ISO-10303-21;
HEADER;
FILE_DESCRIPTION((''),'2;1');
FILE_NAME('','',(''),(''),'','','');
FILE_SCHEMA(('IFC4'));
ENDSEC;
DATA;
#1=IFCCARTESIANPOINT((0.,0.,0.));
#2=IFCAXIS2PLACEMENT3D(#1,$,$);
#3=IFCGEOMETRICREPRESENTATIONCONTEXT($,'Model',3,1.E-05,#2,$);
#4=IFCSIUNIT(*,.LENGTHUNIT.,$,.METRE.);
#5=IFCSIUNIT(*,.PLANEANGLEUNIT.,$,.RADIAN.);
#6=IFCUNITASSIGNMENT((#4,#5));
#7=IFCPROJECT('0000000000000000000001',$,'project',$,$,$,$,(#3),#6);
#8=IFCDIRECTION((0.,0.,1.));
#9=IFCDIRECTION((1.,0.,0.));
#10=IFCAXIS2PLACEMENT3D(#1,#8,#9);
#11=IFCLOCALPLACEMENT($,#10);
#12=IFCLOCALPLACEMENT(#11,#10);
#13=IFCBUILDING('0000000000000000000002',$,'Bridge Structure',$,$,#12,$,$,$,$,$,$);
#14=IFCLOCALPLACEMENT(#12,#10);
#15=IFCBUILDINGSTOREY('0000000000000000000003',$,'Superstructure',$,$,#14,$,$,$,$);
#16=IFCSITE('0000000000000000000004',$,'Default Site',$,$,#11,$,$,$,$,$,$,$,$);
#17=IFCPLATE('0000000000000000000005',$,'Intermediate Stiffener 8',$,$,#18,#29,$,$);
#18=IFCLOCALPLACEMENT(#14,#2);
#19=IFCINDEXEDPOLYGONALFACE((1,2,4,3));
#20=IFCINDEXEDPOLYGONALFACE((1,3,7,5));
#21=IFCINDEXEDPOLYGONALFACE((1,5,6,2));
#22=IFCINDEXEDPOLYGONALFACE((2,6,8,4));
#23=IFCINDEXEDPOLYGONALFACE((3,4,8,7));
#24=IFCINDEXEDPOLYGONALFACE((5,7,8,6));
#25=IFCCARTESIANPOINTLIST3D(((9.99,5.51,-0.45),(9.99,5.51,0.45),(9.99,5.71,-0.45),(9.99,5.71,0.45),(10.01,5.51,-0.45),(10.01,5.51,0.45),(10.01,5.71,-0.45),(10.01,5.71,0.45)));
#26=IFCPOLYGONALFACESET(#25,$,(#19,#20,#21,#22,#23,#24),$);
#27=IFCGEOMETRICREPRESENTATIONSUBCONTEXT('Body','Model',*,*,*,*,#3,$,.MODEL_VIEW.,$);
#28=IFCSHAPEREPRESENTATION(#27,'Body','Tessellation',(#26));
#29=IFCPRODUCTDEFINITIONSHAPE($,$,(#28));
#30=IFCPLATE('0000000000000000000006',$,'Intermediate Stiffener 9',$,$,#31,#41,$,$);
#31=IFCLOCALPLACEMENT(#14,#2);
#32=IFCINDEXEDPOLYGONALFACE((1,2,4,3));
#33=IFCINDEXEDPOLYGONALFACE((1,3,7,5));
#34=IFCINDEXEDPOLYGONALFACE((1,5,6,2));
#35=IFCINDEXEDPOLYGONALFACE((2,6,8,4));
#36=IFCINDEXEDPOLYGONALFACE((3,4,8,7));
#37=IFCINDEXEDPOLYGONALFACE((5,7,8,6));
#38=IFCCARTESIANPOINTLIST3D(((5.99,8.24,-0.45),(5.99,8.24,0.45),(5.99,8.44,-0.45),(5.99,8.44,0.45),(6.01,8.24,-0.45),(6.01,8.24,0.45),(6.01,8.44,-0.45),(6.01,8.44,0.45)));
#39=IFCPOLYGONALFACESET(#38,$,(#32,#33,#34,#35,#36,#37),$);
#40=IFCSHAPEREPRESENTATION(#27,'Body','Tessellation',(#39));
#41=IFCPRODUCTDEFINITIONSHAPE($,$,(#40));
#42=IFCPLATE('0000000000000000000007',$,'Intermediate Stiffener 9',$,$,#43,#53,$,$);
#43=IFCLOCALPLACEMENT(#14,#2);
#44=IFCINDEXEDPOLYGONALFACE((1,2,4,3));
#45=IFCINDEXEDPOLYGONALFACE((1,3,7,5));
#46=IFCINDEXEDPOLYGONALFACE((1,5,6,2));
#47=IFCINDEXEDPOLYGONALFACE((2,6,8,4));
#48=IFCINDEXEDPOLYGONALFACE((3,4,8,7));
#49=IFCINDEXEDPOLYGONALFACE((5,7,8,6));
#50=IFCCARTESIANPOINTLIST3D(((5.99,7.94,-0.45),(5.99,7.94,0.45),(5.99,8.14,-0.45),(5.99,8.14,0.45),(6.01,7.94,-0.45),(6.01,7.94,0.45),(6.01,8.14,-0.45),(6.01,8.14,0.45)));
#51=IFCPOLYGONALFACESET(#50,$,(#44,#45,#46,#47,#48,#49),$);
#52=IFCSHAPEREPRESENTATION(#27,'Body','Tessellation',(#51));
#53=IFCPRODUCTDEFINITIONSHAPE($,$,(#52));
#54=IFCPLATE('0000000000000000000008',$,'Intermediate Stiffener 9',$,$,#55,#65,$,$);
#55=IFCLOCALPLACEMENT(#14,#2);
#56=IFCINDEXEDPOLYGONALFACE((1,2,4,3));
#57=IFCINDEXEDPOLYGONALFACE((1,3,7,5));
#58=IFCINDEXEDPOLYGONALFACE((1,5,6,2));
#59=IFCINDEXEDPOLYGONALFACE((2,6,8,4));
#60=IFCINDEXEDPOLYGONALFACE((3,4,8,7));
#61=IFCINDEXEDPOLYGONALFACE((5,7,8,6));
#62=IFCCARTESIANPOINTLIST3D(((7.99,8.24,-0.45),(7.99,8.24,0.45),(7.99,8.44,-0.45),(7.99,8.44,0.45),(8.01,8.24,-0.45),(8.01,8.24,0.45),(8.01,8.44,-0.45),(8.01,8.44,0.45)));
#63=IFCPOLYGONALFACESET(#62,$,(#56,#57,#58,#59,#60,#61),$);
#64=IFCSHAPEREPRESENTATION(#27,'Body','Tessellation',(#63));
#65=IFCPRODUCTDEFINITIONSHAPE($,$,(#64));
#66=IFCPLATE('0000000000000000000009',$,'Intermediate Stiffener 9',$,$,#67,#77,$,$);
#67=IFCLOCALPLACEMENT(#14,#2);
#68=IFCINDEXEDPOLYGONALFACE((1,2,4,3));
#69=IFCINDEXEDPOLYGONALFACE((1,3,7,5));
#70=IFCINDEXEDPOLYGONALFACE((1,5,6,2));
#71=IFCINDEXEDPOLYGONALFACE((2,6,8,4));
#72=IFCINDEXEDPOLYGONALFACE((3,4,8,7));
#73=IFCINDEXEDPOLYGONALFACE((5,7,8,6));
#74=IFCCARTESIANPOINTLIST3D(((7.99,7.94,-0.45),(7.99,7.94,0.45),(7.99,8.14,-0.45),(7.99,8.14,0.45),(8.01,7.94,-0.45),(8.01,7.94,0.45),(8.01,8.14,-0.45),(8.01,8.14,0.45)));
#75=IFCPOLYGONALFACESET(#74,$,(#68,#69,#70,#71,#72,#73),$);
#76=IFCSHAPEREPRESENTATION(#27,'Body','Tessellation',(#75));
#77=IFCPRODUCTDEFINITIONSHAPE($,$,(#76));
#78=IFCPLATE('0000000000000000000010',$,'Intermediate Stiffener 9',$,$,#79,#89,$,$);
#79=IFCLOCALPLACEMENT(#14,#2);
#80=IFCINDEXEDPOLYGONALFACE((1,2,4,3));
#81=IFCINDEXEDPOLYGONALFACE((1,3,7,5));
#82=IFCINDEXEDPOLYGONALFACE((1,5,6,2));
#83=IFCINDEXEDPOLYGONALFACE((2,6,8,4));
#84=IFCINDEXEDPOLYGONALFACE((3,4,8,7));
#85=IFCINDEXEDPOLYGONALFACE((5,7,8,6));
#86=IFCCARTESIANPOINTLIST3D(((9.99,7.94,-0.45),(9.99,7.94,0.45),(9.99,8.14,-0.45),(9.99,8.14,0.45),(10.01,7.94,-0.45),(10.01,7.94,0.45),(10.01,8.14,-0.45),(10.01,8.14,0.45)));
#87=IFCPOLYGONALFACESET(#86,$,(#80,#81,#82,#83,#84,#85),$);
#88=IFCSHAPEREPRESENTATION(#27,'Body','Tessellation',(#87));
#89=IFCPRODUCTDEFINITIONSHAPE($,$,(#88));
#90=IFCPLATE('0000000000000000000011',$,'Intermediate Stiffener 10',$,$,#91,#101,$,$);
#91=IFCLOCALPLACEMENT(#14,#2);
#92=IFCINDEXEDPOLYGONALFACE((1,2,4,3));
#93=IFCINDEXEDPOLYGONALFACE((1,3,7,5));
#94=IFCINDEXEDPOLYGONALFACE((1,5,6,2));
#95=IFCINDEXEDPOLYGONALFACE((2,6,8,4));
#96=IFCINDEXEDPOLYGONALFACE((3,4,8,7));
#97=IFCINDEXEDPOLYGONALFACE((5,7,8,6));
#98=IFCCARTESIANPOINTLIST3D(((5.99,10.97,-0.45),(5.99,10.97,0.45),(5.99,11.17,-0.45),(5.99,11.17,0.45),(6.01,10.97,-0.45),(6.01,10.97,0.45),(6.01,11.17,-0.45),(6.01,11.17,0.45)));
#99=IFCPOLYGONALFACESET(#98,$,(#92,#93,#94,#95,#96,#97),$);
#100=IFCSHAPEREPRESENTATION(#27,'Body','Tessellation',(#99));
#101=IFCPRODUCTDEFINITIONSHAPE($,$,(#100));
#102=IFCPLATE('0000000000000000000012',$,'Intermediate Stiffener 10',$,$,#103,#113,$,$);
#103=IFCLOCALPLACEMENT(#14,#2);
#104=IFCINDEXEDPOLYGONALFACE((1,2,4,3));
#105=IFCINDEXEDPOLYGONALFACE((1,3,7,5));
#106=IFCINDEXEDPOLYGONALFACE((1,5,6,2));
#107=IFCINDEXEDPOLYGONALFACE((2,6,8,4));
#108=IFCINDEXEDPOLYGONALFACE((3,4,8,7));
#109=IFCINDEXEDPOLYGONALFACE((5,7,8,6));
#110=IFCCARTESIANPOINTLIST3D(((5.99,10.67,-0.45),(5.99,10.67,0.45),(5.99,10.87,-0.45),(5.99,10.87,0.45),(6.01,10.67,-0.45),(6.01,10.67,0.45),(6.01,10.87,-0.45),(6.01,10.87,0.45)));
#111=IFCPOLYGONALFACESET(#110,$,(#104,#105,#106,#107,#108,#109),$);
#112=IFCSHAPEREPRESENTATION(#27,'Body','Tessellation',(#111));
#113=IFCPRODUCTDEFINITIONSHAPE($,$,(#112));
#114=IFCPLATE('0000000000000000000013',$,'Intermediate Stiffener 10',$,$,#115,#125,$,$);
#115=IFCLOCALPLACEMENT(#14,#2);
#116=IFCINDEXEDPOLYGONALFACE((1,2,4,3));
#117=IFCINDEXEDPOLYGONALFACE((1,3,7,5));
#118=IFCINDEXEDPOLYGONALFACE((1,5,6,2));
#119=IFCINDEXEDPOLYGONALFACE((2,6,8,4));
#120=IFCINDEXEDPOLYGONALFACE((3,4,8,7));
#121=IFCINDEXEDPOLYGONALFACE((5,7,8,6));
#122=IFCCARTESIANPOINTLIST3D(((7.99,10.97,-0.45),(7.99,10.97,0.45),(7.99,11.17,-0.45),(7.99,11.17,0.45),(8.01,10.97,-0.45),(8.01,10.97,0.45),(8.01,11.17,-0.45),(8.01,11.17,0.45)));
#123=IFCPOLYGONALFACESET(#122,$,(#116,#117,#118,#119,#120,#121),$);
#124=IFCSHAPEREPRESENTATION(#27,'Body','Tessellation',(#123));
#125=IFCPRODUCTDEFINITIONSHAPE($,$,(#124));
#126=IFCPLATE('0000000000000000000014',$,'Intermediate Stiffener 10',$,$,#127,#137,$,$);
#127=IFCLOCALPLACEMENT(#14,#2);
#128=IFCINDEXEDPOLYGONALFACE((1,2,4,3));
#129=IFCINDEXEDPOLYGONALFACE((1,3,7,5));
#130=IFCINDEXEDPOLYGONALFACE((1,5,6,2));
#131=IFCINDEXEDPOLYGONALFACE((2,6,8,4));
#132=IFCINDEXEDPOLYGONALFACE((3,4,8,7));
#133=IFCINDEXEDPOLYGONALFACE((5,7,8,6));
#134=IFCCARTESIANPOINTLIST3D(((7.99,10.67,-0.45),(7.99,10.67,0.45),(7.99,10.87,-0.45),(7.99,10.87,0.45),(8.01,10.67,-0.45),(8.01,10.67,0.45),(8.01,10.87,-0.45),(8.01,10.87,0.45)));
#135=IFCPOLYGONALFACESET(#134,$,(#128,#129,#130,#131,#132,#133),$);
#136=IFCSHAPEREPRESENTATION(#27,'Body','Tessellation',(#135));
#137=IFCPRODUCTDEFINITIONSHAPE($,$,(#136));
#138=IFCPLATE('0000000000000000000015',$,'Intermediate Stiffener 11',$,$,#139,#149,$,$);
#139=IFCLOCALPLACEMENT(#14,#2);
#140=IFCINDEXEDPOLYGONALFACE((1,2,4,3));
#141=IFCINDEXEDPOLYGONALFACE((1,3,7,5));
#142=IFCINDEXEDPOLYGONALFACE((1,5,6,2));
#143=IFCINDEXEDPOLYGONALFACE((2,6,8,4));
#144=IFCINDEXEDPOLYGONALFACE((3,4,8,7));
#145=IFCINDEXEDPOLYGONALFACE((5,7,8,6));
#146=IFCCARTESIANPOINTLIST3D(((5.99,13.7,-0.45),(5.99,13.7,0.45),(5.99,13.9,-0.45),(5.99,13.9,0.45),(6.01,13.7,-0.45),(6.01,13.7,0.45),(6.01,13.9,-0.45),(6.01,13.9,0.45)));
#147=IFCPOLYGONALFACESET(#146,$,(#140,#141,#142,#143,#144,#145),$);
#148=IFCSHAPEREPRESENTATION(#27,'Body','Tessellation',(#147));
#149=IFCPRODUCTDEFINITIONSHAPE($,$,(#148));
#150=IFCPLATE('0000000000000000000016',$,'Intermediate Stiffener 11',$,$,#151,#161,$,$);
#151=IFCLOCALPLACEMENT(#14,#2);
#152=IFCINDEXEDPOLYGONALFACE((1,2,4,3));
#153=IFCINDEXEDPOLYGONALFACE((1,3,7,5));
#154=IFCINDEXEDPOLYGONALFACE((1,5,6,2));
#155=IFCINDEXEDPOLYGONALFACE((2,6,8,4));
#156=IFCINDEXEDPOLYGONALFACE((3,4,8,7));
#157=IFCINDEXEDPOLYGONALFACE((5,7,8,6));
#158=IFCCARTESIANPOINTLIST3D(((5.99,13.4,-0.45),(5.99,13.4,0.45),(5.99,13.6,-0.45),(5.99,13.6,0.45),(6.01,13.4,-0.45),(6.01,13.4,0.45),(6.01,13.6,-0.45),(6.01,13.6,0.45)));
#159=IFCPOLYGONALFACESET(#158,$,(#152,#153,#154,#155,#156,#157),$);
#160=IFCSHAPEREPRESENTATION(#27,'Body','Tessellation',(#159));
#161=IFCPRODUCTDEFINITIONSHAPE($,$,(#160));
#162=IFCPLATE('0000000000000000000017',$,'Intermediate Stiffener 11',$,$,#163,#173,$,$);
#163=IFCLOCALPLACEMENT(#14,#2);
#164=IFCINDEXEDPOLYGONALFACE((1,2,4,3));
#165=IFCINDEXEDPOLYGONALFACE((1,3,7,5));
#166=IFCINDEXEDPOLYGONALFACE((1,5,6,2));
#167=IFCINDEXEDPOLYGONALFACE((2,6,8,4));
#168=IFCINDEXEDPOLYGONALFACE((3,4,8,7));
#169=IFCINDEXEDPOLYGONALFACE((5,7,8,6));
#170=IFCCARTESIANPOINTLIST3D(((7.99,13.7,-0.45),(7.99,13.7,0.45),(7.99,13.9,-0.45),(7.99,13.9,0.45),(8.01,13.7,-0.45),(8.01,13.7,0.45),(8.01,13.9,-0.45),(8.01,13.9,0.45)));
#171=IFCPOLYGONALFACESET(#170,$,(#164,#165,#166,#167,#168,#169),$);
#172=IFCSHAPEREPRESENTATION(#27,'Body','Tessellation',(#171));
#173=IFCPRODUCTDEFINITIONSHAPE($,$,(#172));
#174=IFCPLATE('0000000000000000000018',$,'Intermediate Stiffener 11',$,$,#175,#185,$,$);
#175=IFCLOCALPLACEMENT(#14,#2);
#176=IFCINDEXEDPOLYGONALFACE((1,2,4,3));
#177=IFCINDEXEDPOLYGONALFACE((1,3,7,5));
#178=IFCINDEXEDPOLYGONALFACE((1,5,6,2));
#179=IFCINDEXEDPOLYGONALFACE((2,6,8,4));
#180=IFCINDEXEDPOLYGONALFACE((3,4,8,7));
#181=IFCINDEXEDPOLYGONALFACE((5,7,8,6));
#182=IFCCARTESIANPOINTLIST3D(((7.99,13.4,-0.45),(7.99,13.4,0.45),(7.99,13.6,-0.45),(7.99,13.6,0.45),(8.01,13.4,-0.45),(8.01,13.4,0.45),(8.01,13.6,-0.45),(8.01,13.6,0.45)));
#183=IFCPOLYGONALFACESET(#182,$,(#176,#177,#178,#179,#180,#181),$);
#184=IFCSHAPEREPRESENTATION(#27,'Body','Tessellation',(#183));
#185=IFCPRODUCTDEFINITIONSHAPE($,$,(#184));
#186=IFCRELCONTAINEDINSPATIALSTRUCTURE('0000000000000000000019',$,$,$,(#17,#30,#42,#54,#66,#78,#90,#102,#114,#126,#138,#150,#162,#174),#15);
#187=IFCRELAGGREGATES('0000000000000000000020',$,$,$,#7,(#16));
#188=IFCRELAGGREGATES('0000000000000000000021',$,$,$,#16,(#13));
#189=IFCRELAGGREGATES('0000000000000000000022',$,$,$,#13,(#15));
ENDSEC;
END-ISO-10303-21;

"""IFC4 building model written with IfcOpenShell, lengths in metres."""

from ifc_helpers import new_model, si_unit, frame, origin, origin_with_axes, origin_2d_with_axis, place, context, subcontext, project, spatial, rectangle, extrude, element, save


model = new_model("IFC4")

# Units and contexts
model_context = context("Model", 3, precision=1e-05, world=origin())
body_context = subcontext(model_context, "Body", "Model", "MODEL_VIEW")
ifc_project = project(units=[si_unit("LENGTHUNIT", "METRE"), si_unit("PLANEANGLEUNIT", "RADIAN")], contexts=[model_context])

# Site, building, storey
site_placement = place(None, origin_with_axes())
site = spatial("IfcSite", under=ifc_project, at=site_placement, Name="Default Site")
building_placement = place(site_placement, origin_with_axes())
building = spatial("IfcBuilding", under=site, at=building_placement, Name="Bridge Structure")
storey_placement = place(building_placement, origin_with_axes())
storey = spatial("IfcBuildingStorey", under=building, at=storey_placement, Name="Superstructure")

# Plates
for number, where, z_axis, x_axis, name in (
    (1, (10.0, 5.61, -0.45), (0.0, 0.0, 1.0), (1.0, 0.0, 0.0), "Intermediate Stiffener 8"),
    (2, (6.0, 8.34, -0.45), (0.0, 0.0, 1.0), (1.0, 0.0, 0.0), "Intermediate Stiffener 9"),
    (3, (6.0, 8.04, -0.45), (0.0, 0.0, 1.0), (1.0, 0.0, 0.0), "Intermediate Stiffener 9"),
    (4, (8.0, 8.34, -0.45), (0.0, 0.0, 1.0), (1.0, 0.0, 0.0), "Intermediate Stiffener 9"),
    (5, (8.0, 8.04, -0.45), (0.0, 0.0, 1.0), (1.0, 0.0, 0.0), "Intermediate Stiffener 9"),
    (6, (10.0, 8.04, -0.45), (0.0, 0.0, 1.0), (1.0, 0.0, 0.0), "Intermediate Stiffener 9"),
    (7, (6.0, 11.07, -0.45), (0.0, 0.0, 1.0), (1.0, 0.0, 0.0), "Intermediate Stiffener 10"),
    (8, (6.0, 10.77, -0.45), (0.0, 0.0, 1.0), (1.0, 0.0, 0.0), "Intermediate Stiffener 10"),
    (9, (8.0, 11.07, -0.45), (0.0, 0.0, 1.0), (1.0, 0.0, 0.0), "Intermediate Stiffener 10"),
    (10, (8.0, 10.77, -0.45), (0.0, 0.0, 1.0), (1.0, 0.0, 0.0), "Intermediate Stiffener 10"),
    (11, (6.0, 13.8, -0.45), (0.0, 0.0, 1.0), (1.0, 0.0, 0.0), "Intermediate Stiffener 11"),
    (12, (6.0, 13.5, -0.45), (0.0, 0.0, 1.0), (1.0, 0.0, 0.0), "Intermediate Stiffener 11"),
    (13, (8.0, 13.8, -0.45), (0.0, 0.0, 1.0), (1.0, 0.0, 0.0), "Intermediate Stiffener 11"),
    (14, (8.0, 13.5, -0.45), (0.0, 0.0, 1.0), (1.0, 0.0, 0.0), "Intermediate Stiffener 11"),
):
    element("IfcPlate", number, at=place(storey_placement, frame(where, z_axis=z_axis, x_axis=x_axis)), inside=storey, Name=name, context=body_context, shape_type="SweptSolid", body=[
        extrude(rectangle(XDim=0.02, YDim=0.2, at=origin_2d_with_axis()), origin_with_axes(), (0.0, 0.0, 1.0), 0.9),
    ])

save(model, "model.ifc")
